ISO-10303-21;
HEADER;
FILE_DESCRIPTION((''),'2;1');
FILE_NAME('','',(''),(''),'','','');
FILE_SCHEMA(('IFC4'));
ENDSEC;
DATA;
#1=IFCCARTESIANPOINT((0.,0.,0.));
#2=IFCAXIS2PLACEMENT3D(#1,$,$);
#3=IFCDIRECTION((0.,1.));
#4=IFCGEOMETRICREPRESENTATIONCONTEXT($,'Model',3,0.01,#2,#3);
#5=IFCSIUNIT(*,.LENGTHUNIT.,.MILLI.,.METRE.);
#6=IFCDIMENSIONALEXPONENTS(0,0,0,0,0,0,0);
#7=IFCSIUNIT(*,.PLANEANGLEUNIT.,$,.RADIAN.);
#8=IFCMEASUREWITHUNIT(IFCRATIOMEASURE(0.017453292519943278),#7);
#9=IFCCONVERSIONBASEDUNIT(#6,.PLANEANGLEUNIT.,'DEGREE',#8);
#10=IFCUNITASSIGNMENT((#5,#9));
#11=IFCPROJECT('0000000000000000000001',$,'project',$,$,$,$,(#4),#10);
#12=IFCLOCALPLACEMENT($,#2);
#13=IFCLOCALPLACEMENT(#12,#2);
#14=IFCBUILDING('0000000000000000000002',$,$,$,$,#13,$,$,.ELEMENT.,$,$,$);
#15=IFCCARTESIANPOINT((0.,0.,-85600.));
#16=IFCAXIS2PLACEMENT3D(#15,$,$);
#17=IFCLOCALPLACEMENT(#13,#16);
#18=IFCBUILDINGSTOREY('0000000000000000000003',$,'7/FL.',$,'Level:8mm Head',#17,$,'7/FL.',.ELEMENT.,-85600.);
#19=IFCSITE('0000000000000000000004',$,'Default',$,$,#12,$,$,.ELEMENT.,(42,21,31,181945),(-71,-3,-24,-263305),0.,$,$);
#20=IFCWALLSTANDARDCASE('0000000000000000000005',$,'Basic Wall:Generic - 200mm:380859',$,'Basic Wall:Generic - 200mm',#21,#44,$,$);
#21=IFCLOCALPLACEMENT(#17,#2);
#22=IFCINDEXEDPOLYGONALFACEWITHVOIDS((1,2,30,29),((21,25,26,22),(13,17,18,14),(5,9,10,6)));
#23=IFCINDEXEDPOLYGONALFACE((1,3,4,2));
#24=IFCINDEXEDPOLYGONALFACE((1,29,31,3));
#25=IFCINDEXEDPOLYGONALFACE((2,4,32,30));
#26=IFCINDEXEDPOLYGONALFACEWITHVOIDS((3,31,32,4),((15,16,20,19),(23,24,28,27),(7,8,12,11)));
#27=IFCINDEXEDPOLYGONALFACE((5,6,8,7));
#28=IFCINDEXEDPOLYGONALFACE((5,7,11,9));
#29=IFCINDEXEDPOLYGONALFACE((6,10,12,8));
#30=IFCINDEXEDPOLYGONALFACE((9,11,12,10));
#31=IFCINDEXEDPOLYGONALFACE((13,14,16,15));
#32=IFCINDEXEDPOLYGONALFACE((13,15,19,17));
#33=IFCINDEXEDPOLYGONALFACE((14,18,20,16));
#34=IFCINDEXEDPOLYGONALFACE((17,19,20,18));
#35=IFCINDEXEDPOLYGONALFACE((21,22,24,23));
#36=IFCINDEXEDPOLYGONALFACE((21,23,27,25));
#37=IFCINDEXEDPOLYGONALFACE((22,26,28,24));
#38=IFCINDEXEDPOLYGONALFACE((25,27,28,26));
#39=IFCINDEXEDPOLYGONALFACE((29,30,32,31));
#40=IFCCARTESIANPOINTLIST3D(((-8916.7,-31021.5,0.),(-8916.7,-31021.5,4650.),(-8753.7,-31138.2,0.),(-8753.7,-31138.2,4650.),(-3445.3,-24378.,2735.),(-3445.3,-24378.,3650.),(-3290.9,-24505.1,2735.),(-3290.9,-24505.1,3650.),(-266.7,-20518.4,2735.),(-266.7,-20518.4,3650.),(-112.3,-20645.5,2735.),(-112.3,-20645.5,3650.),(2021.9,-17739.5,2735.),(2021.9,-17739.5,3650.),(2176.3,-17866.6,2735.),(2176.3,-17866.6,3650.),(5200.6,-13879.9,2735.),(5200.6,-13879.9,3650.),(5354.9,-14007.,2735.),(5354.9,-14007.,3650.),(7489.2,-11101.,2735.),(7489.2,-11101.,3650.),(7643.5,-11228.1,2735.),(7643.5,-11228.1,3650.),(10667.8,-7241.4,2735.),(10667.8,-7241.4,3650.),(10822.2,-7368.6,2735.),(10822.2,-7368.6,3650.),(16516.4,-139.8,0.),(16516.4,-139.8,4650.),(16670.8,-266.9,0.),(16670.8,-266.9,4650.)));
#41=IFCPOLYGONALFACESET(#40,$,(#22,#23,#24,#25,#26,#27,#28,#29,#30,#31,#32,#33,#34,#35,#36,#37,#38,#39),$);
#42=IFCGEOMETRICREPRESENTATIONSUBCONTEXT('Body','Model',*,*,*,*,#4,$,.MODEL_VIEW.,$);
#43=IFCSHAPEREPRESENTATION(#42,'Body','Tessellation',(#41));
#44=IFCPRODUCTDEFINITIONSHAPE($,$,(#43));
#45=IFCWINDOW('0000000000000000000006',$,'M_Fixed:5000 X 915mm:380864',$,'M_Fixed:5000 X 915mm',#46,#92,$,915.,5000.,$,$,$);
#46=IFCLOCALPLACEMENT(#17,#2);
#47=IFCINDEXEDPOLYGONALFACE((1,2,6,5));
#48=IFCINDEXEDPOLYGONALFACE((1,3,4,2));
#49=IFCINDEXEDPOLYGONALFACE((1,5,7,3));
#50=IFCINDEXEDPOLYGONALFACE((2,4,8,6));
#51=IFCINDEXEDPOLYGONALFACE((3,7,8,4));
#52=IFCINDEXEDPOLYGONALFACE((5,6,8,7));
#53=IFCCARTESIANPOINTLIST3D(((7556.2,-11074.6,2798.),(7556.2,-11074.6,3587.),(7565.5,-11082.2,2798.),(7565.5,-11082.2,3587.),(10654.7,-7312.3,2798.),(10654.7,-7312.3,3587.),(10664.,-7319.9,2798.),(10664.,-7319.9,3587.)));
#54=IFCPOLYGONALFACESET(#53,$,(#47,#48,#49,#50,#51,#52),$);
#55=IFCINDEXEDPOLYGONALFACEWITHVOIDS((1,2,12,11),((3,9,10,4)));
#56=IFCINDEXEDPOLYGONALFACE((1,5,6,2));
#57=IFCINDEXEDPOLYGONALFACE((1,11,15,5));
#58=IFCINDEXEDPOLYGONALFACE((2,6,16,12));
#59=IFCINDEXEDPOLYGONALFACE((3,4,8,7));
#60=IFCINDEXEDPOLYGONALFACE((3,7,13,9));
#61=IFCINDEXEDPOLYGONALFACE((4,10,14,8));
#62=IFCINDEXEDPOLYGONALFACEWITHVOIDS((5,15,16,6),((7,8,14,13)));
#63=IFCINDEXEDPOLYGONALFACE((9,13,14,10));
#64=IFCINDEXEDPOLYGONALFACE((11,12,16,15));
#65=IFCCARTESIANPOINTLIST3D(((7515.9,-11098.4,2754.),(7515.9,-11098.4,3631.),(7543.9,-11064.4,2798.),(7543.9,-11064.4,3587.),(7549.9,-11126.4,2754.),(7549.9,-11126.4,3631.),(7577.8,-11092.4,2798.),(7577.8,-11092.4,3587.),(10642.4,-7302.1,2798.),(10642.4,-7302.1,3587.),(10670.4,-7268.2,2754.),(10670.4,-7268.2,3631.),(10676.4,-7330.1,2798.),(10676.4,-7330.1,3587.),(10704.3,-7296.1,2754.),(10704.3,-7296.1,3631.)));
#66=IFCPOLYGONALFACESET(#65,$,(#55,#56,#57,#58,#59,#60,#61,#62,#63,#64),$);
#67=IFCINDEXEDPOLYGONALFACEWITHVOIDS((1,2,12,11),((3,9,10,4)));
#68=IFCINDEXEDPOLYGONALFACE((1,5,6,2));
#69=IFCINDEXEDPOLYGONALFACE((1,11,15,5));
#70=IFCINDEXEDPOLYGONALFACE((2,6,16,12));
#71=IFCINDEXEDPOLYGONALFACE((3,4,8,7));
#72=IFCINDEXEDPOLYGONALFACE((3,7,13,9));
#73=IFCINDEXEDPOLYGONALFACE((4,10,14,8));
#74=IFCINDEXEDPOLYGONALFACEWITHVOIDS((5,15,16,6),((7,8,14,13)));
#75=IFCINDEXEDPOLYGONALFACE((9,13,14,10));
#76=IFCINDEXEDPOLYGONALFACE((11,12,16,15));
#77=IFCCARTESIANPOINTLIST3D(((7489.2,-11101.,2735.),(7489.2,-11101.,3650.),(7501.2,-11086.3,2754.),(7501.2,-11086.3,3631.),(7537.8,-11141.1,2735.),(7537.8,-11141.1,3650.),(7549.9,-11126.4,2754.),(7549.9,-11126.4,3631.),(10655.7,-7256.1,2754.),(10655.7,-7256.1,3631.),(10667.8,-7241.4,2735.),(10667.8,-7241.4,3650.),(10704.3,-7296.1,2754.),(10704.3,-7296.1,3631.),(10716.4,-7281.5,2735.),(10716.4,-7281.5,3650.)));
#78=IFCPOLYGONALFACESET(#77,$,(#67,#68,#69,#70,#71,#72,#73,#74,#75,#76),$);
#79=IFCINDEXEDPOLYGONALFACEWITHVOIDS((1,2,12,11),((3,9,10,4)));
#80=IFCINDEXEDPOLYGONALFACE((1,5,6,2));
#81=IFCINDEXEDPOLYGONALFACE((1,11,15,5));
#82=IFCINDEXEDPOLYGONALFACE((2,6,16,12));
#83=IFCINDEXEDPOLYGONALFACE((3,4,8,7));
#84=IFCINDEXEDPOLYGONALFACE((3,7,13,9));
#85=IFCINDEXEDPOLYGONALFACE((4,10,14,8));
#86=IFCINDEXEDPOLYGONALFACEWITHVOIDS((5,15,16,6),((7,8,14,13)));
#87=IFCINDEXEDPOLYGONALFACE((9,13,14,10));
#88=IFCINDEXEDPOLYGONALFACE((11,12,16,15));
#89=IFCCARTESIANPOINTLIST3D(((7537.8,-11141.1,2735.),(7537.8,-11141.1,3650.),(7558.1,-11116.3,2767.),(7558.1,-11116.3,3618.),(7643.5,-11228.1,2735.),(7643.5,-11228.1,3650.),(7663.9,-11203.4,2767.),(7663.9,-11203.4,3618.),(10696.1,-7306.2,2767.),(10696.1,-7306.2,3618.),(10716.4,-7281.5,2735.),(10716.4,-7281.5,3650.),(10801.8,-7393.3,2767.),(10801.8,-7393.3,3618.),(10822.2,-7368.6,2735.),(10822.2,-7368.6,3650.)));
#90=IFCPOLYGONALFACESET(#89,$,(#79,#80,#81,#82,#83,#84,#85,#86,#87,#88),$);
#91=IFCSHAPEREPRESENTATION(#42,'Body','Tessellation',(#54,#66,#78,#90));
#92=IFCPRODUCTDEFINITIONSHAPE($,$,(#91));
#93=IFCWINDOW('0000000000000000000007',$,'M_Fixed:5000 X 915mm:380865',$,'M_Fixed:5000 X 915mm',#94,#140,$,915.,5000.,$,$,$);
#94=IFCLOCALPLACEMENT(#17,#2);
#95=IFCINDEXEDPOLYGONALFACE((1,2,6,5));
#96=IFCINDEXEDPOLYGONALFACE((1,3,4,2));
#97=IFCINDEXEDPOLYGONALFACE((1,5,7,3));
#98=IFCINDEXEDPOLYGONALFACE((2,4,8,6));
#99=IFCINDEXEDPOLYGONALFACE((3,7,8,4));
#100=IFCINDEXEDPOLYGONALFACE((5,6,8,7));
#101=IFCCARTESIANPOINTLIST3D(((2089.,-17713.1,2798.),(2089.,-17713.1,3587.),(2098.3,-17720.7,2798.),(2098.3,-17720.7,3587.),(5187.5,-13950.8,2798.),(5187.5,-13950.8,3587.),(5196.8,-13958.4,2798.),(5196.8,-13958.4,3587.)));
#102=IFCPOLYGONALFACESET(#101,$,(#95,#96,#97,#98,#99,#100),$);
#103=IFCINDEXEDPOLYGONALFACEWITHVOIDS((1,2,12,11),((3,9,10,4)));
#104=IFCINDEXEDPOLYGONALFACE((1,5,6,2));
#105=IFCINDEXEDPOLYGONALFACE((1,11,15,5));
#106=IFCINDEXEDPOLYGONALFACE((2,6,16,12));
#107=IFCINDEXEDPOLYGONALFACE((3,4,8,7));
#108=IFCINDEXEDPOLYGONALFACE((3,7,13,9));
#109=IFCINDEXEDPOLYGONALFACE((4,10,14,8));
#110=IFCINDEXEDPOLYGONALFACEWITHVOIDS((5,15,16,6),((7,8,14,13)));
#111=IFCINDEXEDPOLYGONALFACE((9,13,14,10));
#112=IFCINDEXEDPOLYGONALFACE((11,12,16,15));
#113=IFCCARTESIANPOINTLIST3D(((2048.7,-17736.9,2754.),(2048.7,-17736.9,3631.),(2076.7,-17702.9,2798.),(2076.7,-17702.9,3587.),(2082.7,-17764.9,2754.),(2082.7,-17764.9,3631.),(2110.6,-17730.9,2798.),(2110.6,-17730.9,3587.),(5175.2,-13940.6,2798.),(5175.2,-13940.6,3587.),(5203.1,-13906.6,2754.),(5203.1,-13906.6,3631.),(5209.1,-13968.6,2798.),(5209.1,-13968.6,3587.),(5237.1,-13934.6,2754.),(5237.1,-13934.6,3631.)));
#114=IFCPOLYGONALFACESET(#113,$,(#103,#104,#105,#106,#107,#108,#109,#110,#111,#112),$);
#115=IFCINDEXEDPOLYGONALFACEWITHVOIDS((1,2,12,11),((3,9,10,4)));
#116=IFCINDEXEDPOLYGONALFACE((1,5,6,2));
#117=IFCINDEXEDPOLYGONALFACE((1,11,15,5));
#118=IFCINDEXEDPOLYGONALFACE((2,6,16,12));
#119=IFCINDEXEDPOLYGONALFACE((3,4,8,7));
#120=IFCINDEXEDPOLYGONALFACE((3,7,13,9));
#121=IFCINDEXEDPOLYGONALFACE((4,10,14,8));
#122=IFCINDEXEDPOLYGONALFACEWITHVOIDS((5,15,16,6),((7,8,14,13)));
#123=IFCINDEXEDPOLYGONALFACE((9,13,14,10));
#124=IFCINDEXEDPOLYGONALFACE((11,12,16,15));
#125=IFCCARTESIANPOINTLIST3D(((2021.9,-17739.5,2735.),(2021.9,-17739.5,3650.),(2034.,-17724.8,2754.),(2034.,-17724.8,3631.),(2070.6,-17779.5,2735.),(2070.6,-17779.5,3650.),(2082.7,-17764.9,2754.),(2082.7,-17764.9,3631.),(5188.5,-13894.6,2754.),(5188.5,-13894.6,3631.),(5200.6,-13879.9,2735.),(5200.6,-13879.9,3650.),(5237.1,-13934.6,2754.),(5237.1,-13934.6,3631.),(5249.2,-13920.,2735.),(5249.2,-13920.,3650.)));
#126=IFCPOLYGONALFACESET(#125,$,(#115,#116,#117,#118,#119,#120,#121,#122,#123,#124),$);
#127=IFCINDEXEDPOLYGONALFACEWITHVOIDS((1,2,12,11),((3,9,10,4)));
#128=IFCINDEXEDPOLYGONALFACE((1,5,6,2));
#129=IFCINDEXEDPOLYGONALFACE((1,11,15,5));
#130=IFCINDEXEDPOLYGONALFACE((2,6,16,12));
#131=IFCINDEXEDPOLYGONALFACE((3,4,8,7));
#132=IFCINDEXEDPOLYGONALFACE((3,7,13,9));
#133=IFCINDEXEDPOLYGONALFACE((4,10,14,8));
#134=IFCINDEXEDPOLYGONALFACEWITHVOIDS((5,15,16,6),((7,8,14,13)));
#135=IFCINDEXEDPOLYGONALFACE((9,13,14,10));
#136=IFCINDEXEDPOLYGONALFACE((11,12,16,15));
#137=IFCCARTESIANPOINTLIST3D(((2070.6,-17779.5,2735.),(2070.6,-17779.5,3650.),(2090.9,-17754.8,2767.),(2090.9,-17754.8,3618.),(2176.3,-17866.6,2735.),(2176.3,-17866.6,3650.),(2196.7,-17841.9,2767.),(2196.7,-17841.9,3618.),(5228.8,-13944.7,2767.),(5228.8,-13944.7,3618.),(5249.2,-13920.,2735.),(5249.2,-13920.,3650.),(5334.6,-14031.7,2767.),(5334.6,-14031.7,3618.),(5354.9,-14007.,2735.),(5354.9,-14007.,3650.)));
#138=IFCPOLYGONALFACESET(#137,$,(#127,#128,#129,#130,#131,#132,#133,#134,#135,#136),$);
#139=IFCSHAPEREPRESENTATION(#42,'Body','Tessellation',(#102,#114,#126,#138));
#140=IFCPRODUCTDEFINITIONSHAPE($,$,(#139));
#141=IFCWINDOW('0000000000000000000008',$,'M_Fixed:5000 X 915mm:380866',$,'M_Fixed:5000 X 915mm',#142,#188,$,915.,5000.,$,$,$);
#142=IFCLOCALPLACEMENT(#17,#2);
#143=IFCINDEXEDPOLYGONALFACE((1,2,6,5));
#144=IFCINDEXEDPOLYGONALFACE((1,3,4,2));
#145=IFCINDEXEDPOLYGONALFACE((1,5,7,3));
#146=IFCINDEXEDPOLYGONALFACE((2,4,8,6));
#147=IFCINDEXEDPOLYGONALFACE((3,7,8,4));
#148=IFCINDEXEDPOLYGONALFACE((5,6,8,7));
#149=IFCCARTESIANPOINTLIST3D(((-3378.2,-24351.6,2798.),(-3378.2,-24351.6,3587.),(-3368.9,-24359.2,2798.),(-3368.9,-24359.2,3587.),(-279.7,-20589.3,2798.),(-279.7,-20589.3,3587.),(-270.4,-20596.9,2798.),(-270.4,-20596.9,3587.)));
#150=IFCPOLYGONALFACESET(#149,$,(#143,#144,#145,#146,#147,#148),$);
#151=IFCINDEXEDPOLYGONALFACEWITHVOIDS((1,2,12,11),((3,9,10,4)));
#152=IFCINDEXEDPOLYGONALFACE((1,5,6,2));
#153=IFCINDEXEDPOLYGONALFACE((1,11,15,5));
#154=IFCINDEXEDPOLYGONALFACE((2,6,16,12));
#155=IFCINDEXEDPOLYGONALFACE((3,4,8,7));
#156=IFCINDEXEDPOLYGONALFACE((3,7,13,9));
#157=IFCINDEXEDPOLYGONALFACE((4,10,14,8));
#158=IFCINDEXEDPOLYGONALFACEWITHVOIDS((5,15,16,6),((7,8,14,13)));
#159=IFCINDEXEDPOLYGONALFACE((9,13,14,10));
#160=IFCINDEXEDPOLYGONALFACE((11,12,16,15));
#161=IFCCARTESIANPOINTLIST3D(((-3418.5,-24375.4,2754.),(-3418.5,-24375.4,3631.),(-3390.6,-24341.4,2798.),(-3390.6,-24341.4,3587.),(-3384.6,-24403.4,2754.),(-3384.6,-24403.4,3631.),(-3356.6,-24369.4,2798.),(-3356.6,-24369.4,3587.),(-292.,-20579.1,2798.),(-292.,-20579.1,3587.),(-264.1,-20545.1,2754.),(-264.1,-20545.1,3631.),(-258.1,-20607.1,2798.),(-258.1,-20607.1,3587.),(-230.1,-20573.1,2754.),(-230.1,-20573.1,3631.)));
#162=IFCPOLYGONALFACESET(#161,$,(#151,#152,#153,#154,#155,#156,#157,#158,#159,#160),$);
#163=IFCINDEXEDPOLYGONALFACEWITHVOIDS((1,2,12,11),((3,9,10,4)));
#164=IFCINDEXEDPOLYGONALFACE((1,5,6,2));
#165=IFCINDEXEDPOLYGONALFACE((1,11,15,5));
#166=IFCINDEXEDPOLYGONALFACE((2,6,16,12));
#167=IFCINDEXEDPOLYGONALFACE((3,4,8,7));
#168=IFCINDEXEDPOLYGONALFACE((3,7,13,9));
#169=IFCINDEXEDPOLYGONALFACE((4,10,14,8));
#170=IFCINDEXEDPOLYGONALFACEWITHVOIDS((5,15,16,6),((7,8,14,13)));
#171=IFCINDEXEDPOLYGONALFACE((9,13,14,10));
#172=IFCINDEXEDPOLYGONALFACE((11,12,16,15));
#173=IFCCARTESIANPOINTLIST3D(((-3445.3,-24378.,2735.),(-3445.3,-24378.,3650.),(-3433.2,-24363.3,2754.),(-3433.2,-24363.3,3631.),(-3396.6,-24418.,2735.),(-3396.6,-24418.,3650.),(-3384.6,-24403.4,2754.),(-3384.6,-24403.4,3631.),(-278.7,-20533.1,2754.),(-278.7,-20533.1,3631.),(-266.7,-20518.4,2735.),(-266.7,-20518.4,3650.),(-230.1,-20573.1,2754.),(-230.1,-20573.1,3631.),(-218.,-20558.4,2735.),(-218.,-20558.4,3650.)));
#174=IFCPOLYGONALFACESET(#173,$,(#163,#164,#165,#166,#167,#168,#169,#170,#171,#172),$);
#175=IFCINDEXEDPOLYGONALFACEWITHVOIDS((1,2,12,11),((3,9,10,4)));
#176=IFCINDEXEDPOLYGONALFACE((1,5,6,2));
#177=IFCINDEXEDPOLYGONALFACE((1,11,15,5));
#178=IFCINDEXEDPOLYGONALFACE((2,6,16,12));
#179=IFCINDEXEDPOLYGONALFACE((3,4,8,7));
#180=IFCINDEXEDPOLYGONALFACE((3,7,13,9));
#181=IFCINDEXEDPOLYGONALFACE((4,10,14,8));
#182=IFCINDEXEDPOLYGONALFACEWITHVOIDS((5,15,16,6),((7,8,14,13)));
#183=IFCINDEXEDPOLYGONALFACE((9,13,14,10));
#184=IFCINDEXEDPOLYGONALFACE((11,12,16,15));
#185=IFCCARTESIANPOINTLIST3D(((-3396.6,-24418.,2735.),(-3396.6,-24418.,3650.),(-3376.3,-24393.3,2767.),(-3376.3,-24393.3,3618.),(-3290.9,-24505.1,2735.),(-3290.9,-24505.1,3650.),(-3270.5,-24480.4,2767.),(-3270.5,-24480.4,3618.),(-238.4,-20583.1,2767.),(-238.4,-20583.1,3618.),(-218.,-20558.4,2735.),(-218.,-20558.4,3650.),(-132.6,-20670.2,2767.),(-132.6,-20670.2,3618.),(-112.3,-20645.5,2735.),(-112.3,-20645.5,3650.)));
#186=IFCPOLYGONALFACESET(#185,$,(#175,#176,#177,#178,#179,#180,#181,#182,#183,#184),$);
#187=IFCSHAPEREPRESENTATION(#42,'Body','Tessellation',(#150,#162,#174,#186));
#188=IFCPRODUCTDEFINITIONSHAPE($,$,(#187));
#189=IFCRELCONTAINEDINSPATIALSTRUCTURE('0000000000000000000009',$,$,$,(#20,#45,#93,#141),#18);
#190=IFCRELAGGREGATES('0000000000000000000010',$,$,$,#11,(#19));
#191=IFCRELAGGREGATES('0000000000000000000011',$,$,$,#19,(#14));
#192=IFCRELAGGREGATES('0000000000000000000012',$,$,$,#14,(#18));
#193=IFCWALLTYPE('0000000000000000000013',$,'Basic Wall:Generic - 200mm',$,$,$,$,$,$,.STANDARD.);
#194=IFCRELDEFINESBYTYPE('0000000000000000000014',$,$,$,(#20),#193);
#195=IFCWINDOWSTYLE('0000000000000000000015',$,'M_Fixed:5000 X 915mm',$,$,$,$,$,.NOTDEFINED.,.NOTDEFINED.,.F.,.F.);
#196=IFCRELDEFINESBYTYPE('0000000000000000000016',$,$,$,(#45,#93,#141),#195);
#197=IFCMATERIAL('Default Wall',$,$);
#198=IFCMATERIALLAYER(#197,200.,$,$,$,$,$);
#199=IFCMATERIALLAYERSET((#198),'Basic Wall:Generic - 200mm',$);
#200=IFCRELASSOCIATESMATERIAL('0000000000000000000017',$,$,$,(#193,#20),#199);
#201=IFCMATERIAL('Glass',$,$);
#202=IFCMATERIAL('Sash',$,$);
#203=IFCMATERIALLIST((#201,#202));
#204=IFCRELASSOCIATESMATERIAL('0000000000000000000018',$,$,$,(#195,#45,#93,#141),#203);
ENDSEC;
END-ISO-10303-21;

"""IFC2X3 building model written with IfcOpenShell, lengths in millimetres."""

from ifc_helpers import new_model, entity, si_unit, converted_unit, direction, frame, frame_2d, origin, place, context, subcontext, project, spatial, polyline, rectangle, outline, extrude, source, transform, mapped, material, material_list, layer, layer_set, layer_usage, type_object, type_shapes, element, fill, save


model = new_model("IFC2X3")

# Units and contexts
model_context = context("Model", 3, precision=0.01, world=origin(), true_north=direction((0.0, 1.0)))
body_context = subcontext(model_context, "Body", "Model", "MODEL_VIEW")
ifc_project = project(units=[si_unit("LENGTHUNIT", "METRE", prefix="MILLI"), converted_unit("PLANEANGLEUNIT", "DEGREE", entity("IfcRatioMeasure", 0.017453292519943278), si_unit("PLANEANGLEUNIT", "RADIAN"), dimensions=[0, 0, 0, 0, 0, 0, 0])], contexts=[model_context])

# Site, building, storey
site_placement = place(None, origin())
site = spatial("IfcSite", under=ifc_project, at=site_placement, Name="Default", CompositionType="ELEMENT", RefLatitude=(42, 21, 31, 181945), RefLongitude=(-71, -3, -24, -263305), RefElevation=0.0)
building_placement = place(site_placement, origin())
building = spatial("IfcBuilding", under=site, at=building_placement, CompositionType="ELEMENT")
storey_placement = place(building_placement, frame((0.0, 0.0, -85600.0)))
storey = spatial("IfcBuildingStorey", under=building, at=storey_placement, Name="7/FL.", ObjectType="Level:8mm Head", LongName="7/FL.", CompositionType="ELEMENT", Elevation=-85600.0)

# Shared definitions
ifc_material_1 = material(Name="Default Wall")
ifc_layer = layer(ifc_material_1, 200.0)
ifc_layer_set = layer_set([ifc_layer], Name="Basic Wall:Generic - 200mm")
ifc_layer_usage = layer_usage(ifc_layer_set, "AXIS2", "NEGATIVE", 100.0)
wall_type = type_object("IfcWallType", Name="Basic Wall:Generic - 200mm", PredefinedType="STANDARD", material=ifc_layer_set)

# Wall, openings, windows
wall_1_placement = place(storey_placement, frame((17102.2, 414.2, 0.0), z_axis=(0.0, 0.0, 1.0), x_axis=(-0.635723, -0.771917, 0.0)))
wall_1 = element("IfcWallStandardCase", 1, at=wall_1_placement, inside=storey, type_object=wall_type, material=ifc_layer_usage, Name="Basic Wall:Generic - 200mm:380859", ObjectType="Basic Wall:Generic - 200mm", context=body_context, shape_type="SweptSolid", body=[
    extrude(outline(polyline([(40806.5, -100.0), (40793.0, 100.0), (37219.3, 100.0), (37019.3, 100.0), (800.0, 100.0), (800.0, -100.0), (37019.3, -100.0), (37219.3, -100.0), (40806.5, -100.0)])), origin(), (0.0, 0.0, 1.0), 4650.0),
])
opening_1_placement = place(wall_1_placement, origin())
element("IfcOpeningElement", 2, at=opening_1_placement, cuts=wall_1, ObjectType="Opening", context=body_context, shape_type="SweptSolid", body=[
    extrude(rectangle(XDim=1000.0, YDim=1012.7, at=frame_2d((0.0, 0.0), x_axis=(1.0, 0.0))), frame((293.7, -183.3, 500.0), z_axis=(0.0, 1.0, 0.0), x_axis=(0.0, 0.0, -1.0)), (0.0, 0.0, 1.0), 1010.1),
])
opening_2_placement = place(wall_1_placement, frame((15000.0, 100.0, 2735.0)))
opening_2 = element("IfcOpeningElement", 3, at=opening_2_placement, cuts=wall_1, ObjectType="Opening", context=body_context, shape_type="SweptSolid", body=[
    extrude(rectangle(XDim=915.0, YDim=5000.0, at=frame_2d((457.5, 2500.0), x_axis=(1.0, 0.0))), frame((0.0, 0.0, 0.0), z_axis=(0.0, -1.0, 0.0), x_axis=(0.0, 0.0, 1.0)), (0.0, 0.0, 1.0), 200.0),
])
opening_3_placement = place(wall_1_placement, frame((23600.0, 100.0, 2735.0)))
opening_3 = element("IfcOpeningElement", 4, at=opening_3_placement, cuts=wall_1, ObjectType="Opening", context=body_context, shape_type="SweptSolid", body=[
    extrude(rectangle(XDim=915.0, YDim=5000.0, at=frame_2d((457.5, 2500.0), x_axis=(1.0, 0.0))), frame((0.0, 0.0, 0.0), z_axis=(0.0, -1.0, 0.0), x_axis=(0.0, 0.0, 1.0)), (0.0, 0.0, 1.0), 200.0),
])
opening_4_placement = place(wall_1_placement, frame((32200.0, 100.0, 2735.0)))
opening_4 = element("IfcOpeningElement", 5, at=opening_4_placement, cuts=wall_1, ObjectType="Opening", context=body_context, shape_type="SweptSolid", body=[
    extrude(rectangle(XDim=915.0, YDim=5000.0, at=frame_2d((457.5, 2500.0), x_axis=(1.0, 0.0))), frame((0.0, 0.0, 0.0), z_axis=(0.0, -1.0, 0.0), x_axis=(0.0, 0.0, 1.0)), (0.0, 0.0, 1.0), 200.0),
])
ifc_material_2 = material(Name="Glass")
ifc_material_3 = material(Name="Sash")
ifc_material_list = material_list([ifc_material_2, ifc_material_3])
window_style_1 = type_object("IfcWindowStyle", Name="M_Fixed:5000 X 915mm", ConstructionType="NOTDEFINED", OperationType="NOTDEFINED", ParameterTakesPrecedence=False, Sizeable=False, material=ifc_material_list)
shared_shape_1 = source(origin(), body_context, "Body", "SweptSolid", [
    extrude(rectangle(XDim=12.0, YDim=4874.0, at=frame_2d((0.0, 0.0), x_axis=(1.0, 0.0))), frame((2500.0, 159.0, 63.0), z_axis=(0.0, 0.0, 1.0), x_axis=(0.0, -1.0, 0.0)), (0.0, 0.0, 1.0), 789.0),
    extrude(outline(polyline([(-2481.0, -438.5), (2481.0, -438.5), (2481.0, 438.5), (-2481.0, 438.5), (-2481.0, -438.5)]), holes=[polyline([(-2437.0, -394.5), (-2437.0, 394.5), (2437.0, 394.5), (2437.0, -394.5), (-2437.0, -394.5)])]), frame((2500.0, 137.0, 457.5), z_axis=(0.0, 1.0, 0.0), x_axis=(1.0, 0.0, 0.0)), (0.0, 0.0, 1.0), 44.0),
    extrude(outline(polyline([(-2500.0, -457.5), (2500.0, -457.5), (2500.0, 457.5), (-2500.0, 457.5), (-2500.0, -457.5)]), holes=[polyline([(-2481.0, -438.5), (-2481.0, 438.5), (2481.0, 438.5), (2481.0, -438.5), (-2481.0, -438.5)])]), frame((2500.0, 137.0, 457.5), z_axis=(0.0, 1.0, 0.0), x_axis=(1.0, 0.0, 0.0)), (0.0, 0.0, 1.0), 63.0),
    extrude(outline(polyline([(-2500.0, -457.5), (2500.0, -457.5), (2500.0, 457.5), (-2500.0, 457.5), (-2500.0, -457.5)]), holes=[polyline([(-2468.0, -425.5), (-2468.0, 425.5), (2468.0, 425.5), (2468.0, -425.5), (-2468.0, -425.5)])]), frame((2500.0, 0.0, 457.5), z_axis=(0.0, 1.0, 0.0), x_axis=(1.0, 0.0, 0.0)), (0.0, 0.0, 1.0), 137.0),
])
type_shapes(window_style_1, [shared_shape_1])
window_1_placement = place(opening_2_placement, frame((0.0, 0.0, 0.0), z_axis=(0.0, 0.0, 1.0), x_axis=(-1.0, 0.0, 0.0)))
window_1 = element("IfcWindow", 6, at=window_1_placement, inside=storey, type_object=window_style_1, material=ifc_material_list, Name="M_Fixed:5000 X 915mm:380864", ObjectType="M_Fixed:5000 X 915mm", OverallHeight=915.0, OverallWidth=5000.0, context=body_context, shape_type="MappedRepresentation", body=[
    mapped(shared_shape_1, transform((0.0, 0.0, 0.0), scale=1.0)),
])
fill(opening_2, window_1)
window_2_placement = place(opening_3_placement, frame((0.0, 0.0, 0.0), z_axis=(0.0, 0.0, 1.0), x_axis=(-1.0, 0.0, 0.0)))
window_2 = element("IfcWindow", 7, at=window_2_placement, inside=storey, type_object=window_style_1, material=ifc_material_list, Name="M_Fixed:5000 X 915mm:380865", ObjectType="M_Fixed:5000 X 915mm", OverallHeight=915.0, OverallWidth=5000.0, context=body_context, shape_type="MappedRepresentation", body=[
    mapped(shared_shape_1, transform((0.0, 0.0, 0.0), scale=1.0)),
])
fill(opening_3, window_2)
window_3_placement = place(opening_4_placement, frame((0.0, 0.0, 0.0), z_axis=(0.0, 0.0, 1.0), x_axis=(-1.0, 0.0, 0.0)))
window_3 = element("IfcWindow", 8, at=window_3_placement, inside=storey, type_object=window_style_1, material=ifc_material_list, Name="M_Fixed:5000 X 915mm:380866", ObjectType="M_Fixed:5000 X 915mm", OverallHeight=915.0, OverallWidth=5000.0, context=body_context, shape_type="MappedRepresentation", body=[
    mapped(shared_shape_1, transform((0.0, 0.0, 0.0), scale=1.0)),
])
fill(opening_4, window_3)

save(model, "model.ifc")
